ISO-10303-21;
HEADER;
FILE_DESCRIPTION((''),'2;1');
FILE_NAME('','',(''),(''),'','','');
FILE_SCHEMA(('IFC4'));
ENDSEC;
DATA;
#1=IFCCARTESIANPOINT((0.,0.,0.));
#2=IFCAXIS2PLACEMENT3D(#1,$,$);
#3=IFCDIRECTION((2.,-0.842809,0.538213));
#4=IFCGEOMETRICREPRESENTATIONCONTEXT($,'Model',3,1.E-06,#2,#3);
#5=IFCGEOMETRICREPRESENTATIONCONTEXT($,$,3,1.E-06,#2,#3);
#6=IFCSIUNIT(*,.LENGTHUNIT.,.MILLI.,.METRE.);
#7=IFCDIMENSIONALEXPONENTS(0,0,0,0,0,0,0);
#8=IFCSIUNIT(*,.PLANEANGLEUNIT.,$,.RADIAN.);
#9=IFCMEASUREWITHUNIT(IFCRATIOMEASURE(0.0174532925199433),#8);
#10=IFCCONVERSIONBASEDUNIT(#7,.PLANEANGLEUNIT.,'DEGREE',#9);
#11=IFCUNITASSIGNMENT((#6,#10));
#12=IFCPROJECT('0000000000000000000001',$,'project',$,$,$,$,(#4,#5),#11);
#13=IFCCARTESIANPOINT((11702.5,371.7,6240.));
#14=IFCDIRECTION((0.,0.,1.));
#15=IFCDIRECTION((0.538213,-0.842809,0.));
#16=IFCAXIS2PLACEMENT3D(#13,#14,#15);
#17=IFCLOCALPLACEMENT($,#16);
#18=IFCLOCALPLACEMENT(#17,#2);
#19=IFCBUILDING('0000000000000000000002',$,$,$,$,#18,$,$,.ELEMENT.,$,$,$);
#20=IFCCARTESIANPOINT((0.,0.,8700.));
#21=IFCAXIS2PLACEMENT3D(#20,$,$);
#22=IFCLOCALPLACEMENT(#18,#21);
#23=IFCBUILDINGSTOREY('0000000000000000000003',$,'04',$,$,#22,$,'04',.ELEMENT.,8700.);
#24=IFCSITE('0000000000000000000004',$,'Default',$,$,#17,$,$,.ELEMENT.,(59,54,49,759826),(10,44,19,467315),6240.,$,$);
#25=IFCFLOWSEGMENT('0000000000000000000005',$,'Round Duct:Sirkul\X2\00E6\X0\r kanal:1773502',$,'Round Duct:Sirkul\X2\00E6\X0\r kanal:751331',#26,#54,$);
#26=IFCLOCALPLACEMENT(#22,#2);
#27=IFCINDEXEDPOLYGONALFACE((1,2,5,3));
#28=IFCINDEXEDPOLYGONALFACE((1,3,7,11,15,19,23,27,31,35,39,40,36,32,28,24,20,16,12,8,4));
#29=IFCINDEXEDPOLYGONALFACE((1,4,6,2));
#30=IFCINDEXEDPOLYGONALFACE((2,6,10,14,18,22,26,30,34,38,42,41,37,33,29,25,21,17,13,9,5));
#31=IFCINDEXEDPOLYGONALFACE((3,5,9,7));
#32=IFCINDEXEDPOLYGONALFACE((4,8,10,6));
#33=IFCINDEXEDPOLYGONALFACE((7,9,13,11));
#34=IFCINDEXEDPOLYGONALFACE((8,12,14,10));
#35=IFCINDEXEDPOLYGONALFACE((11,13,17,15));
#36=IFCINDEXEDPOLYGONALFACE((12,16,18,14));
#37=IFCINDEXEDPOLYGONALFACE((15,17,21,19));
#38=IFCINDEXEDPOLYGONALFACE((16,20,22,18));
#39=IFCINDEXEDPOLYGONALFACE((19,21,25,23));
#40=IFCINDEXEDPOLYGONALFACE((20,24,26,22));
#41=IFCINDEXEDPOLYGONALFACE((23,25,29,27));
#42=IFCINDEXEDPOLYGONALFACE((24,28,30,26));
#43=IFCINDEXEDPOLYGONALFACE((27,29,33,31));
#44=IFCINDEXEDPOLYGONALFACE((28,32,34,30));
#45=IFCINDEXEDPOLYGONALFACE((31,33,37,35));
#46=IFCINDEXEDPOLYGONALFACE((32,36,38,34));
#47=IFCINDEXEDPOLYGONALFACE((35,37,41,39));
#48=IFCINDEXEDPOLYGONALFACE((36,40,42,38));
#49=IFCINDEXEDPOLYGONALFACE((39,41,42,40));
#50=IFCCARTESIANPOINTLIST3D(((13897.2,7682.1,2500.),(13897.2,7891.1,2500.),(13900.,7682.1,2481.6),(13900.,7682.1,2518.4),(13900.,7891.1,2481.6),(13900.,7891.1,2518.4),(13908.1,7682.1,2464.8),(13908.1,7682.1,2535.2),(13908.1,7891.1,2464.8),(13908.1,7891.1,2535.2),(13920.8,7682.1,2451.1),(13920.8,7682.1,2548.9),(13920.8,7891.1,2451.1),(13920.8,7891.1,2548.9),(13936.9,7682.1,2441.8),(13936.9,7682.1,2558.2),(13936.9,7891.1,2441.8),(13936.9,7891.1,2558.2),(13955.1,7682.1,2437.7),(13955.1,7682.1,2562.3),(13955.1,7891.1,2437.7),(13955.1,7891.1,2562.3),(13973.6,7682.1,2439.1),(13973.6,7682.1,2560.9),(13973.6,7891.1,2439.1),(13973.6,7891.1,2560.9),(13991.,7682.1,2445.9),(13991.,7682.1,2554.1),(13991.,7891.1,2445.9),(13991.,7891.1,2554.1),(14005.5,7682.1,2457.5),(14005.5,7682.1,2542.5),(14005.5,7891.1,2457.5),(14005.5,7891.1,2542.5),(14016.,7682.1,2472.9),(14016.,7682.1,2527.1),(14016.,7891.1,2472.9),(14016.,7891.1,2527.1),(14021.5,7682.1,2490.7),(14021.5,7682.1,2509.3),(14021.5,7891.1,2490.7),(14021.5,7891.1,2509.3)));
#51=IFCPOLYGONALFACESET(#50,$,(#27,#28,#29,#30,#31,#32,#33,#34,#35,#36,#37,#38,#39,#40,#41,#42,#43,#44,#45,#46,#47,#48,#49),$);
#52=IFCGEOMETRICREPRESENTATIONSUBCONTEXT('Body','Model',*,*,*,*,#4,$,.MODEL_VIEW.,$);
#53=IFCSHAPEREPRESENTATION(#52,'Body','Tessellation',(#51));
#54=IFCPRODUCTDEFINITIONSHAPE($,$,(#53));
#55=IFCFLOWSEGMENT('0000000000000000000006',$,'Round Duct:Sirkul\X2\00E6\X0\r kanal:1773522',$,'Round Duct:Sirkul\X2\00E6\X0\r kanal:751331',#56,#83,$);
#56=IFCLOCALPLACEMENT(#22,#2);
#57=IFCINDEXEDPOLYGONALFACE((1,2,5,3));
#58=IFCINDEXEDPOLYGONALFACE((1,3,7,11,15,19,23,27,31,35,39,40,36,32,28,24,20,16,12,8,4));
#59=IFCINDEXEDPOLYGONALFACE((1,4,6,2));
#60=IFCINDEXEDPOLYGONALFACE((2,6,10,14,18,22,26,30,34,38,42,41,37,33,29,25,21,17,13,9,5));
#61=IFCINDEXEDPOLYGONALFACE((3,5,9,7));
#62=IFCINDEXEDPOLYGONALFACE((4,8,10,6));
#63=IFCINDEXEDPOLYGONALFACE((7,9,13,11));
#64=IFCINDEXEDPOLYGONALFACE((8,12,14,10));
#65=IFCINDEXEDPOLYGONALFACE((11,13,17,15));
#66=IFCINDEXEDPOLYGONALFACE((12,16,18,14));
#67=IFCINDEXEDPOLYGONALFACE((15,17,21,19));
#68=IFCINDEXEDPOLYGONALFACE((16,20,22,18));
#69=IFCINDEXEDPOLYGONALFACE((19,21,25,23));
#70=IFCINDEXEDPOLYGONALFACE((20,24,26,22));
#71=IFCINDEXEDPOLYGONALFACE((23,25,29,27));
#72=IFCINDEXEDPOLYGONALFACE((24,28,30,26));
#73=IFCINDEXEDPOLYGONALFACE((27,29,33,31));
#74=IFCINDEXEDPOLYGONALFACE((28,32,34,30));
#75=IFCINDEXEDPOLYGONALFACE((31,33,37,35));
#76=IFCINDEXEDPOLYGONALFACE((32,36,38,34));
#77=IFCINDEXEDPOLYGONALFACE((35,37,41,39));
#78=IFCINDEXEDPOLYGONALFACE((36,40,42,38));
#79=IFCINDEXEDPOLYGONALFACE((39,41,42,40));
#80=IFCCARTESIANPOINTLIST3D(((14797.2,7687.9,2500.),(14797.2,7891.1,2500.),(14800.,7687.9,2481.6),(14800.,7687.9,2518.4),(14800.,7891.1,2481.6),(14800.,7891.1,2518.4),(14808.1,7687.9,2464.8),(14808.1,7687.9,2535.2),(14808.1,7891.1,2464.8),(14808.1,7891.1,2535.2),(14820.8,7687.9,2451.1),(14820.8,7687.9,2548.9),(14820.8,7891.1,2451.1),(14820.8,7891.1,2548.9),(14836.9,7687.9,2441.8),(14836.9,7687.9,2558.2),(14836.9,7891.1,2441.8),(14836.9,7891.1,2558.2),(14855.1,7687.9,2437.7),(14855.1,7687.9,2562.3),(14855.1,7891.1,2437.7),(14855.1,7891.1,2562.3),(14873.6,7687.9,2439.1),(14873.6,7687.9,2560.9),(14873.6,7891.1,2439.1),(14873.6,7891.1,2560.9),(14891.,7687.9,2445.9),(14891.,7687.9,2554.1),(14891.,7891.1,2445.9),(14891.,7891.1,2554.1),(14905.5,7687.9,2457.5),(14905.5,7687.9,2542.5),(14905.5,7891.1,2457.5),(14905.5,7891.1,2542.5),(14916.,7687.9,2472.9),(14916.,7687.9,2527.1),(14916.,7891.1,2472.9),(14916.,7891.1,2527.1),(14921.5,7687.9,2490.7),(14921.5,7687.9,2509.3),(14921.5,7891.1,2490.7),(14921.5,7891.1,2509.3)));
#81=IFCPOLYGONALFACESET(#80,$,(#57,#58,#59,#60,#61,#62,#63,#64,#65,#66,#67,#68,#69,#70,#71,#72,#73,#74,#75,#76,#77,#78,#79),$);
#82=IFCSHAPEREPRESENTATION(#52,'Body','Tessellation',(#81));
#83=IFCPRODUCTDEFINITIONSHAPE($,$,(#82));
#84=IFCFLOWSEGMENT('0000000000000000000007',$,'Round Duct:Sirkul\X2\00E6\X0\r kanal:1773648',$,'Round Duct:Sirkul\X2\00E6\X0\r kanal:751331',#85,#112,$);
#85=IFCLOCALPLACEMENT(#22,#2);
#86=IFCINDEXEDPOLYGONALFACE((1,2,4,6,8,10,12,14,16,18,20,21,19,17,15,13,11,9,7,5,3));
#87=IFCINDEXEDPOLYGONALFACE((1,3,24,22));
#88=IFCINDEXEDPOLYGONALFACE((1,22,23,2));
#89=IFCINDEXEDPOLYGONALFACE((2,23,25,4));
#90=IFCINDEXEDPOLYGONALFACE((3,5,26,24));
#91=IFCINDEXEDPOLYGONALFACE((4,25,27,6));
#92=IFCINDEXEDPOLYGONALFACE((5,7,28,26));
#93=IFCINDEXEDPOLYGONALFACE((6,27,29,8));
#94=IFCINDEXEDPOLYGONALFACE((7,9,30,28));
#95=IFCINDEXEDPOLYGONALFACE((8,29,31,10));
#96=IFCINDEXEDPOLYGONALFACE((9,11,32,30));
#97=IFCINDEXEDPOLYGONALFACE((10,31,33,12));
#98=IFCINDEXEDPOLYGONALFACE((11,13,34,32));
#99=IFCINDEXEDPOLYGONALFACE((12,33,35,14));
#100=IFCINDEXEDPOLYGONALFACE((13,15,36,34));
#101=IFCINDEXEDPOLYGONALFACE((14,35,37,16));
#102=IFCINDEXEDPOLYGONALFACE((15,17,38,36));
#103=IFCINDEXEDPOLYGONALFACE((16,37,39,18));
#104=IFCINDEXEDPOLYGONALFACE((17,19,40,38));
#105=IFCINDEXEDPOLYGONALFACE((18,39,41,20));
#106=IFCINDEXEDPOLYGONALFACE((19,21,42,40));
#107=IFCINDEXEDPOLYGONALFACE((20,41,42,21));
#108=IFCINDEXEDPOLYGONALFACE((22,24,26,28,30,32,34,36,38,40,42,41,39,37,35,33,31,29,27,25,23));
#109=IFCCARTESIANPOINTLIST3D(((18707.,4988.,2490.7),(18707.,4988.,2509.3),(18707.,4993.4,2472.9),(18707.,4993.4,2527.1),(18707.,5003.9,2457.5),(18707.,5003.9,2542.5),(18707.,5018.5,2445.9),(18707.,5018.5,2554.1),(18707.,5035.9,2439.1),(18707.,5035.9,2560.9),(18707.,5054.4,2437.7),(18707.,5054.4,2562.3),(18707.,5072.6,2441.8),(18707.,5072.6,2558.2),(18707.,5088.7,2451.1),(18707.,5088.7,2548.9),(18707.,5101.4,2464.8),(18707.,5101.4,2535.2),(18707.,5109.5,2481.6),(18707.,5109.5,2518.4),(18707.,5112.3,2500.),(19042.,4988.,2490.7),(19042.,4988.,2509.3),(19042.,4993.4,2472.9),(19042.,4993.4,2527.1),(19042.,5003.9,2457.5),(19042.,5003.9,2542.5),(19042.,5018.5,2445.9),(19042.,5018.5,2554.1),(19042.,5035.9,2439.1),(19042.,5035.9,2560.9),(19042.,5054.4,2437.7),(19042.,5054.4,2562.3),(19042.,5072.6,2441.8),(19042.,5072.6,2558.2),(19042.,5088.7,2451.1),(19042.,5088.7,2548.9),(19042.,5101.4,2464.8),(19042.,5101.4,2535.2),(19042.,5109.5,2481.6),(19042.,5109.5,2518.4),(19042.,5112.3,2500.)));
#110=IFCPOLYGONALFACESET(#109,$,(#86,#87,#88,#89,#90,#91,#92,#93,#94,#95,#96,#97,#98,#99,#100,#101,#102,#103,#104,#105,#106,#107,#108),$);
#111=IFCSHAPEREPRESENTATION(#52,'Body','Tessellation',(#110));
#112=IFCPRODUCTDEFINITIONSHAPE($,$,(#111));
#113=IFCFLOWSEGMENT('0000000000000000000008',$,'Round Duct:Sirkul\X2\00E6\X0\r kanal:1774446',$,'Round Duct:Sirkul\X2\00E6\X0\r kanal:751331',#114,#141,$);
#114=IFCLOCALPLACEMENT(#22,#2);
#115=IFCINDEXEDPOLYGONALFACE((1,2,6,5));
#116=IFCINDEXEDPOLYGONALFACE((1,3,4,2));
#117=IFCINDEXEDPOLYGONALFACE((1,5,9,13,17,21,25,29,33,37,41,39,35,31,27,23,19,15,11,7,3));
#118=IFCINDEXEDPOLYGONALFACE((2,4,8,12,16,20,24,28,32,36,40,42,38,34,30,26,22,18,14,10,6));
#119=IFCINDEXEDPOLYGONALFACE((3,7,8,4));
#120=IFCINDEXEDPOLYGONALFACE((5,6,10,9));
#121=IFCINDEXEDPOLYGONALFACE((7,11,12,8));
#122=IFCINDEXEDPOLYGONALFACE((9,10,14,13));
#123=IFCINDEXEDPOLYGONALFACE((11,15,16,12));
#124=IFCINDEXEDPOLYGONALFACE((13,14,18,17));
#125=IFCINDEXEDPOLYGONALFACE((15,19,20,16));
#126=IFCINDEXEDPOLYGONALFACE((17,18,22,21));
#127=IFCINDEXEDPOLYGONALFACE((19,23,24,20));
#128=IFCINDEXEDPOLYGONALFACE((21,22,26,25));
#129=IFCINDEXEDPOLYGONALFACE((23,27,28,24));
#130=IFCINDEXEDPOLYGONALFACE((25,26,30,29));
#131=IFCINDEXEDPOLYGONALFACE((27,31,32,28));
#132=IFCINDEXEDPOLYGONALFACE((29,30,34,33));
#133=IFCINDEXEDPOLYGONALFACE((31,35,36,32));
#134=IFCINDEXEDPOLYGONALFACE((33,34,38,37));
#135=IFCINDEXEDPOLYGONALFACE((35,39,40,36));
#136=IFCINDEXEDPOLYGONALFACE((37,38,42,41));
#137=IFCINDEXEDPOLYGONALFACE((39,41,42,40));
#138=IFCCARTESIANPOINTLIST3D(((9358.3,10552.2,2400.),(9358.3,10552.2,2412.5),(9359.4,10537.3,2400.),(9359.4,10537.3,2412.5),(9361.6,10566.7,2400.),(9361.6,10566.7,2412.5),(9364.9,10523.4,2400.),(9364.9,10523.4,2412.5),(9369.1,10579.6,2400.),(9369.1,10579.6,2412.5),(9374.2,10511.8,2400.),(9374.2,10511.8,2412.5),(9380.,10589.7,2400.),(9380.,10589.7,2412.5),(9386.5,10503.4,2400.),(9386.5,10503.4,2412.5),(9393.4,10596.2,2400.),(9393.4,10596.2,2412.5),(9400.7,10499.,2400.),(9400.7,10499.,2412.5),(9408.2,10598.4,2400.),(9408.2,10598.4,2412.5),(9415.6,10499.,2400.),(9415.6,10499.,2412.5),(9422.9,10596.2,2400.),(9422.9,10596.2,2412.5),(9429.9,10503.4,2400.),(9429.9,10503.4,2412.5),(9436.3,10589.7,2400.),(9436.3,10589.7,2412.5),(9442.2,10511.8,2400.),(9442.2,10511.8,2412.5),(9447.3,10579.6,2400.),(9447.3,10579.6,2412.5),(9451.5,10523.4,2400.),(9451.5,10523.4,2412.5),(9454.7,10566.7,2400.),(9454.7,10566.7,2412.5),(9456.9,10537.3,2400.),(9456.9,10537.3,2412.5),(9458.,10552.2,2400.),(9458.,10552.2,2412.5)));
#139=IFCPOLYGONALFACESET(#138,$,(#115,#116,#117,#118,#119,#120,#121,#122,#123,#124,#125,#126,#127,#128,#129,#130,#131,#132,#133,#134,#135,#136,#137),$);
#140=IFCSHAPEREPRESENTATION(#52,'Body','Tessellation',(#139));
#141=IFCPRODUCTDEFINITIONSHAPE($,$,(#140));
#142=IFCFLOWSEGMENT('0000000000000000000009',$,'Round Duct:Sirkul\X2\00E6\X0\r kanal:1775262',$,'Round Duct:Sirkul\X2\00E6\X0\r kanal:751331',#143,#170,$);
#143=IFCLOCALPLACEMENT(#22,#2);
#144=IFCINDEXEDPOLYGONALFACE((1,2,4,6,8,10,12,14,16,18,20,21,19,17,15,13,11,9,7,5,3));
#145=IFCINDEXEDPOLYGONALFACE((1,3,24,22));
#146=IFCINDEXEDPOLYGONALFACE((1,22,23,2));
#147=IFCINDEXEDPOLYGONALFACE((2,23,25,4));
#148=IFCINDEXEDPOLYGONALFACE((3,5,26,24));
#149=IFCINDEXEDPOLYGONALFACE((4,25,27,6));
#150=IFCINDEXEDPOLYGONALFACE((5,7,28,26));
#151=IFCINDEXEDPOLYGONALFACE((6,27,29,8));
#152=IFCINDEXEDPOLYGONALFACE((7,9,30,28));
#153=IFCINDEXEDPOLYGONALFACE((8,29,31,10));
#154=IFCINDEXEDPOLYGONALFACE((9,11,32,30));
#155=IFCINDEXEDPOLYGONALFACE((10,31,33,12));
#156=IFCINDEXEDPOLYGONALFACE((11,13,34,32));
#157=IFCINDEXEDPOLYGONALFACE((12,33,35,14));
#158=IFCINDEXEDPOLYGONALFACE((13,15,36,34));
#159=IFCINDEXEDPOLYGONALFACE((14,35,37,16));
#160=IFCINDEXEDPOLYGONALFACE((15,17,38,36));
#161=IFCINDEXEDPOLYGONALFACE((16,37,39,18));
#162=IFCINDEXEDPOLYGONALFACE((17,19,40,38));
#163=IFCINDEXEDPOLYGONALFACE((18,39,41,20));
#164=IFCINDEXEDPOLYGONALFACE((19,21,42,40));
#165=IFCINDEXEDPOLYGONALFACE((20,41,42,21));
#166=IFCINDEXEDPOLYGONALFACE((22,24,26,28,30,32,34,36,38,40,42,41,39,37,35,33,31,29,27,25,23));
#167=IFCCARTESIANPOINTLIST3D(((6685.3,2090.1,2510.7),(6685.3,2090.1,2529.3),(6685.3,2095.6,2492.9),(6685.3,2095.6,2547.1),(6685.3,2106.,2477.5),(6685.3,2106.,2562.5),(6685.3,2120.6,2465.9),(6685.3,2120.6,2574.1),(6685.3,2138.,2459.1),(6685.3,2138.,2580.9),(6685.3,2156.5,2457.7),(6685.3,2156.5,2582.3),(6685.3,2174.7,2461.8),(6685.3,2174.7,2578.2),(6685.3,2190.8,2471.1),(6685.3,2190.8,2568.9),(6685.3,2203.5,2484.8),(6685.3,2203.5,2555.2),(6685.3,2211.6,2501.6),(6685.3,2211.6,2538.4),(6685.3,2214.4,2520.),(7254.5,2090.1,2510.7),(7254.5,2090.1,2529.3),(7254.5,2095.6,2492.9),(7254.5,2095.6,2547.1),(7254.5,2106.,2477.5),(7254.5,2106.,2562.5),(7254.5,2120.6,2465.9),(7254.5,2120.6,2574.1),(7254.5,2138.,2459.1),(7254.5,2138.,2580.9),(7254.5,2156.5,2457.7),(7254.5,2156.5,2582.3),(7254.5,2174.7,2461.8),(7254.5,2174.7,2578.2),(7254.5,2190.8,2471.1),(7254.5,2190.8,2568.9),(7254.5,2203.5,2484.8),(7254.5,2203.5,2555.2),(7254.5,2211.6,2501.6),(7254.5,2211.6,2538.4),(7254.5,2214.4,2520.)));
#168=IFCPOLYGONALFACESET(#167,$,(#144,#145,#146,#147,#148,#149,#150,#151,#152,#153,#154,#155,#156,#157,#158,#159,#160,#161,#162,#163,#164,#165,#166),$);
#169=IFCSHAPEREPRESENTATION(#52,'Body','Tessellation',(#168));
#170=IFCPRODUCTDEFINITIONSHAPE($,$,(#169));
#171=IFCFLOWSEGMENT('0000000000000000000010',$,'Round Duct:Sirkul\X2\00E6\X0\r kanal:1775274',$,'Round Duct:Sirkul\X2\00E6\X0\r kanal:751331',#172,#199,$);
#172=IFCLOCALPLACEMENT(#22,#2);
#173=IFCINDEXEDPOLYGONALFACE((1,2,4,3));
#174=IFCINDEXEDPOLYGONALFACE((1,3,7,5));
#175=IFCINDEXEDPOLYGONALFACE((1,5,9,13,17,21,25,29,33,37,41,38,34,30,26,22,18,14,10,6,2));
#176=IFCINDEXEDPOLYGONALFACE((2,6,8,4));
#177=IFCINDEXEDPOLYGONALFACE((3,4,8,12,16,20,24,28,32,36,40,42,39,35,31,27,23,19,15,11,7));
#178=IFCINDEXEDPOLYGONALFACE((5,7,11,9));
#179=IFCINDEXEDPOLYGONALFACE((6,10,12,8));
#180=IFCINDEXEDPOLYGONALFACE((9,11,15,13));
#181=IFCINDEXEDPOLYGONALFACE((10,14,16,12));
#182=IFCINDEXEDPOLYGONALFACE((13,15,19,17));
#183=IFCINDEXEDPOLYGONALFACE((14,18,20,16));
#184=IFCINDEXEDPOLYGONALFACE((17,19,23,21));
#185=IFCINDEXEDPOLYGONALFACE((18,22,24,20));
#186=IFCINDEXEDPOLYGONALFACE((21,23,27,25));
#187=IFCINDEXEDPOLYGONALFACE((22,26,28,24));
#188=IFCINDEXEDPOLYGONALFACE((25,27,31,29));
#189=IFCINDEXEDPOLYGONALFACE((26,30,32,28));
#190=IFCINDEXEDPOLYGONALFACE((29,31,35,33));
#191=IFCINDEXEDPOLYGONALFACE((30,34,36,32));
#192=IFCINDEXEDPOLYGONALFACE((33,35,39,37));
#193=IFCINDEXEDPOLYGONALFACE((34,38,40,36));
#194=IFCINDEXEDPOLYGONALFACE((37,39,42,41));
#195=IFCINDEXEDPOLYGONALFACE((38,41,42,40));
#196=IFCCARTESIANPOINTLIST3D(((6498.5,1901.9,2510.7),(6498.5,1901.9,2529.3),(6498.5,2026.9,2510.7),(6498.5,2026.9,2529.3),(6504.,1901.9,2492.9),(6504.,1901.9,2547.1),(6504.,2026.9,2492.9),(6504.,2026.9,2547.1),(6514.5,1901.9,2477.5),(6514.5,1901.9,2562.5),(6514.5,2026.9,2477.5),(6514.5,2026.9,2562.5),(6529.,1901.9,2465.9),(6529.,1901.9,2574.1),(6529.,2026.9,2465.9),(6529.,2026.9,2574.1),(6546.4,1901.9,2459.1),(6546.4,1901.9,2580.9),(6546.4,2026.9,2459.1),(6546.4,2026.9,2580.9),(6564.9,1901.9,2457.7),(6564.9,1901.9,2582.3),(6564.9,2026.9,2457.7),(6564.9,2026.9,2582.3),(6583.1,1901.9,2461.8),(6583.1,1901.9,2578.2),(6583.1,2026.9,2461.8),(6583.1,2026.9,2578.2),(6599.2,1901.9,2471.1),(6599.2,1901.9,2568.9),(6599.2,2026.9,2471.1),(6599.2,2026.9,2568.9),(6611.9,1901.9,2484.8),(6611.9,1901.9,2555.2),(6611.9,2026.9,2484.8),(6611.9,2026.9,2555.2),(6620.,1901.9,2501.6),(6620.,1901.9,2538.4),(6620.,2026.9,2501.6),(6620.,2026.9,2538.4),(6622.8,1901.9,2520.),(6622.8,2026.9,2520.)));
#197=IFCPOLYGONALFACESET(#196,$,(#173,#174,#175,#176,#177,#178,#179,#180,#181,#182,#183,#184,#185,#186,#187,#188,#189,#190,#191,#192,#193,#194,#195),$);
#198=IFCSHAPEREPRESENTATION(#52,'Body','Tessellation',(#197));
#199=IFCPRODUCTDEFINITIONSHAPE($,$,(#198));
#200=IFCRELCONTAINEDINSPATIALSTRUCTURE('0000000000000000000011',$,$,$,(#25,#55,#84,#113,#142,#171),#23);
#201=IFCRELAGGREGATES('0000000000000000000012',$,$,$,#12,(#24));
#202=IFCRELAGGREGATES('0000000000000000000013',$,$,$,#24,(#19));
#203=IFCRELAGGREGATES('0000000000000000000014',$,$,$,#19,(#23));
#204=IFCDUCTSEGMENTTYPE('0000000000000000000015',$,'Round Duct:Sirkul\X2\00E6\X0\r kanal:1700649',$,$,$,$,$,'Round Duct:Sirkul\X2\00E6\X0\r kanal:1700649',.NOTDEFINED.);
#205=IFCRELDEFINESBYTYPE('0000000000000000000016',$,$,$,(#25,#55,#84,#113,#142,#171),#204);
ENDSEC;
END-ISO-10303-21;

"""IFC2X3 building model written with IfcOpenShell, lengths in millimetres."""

from ifc_helpers import new_model, entity, si_unit, converted_unit, direction, frame, frame_2d, origin, place, context, subcontext, project, spatial, circle, extrude, type_object, element, save


model = new_model("IFC2X3")

# Units and contexts
model_context = context("Model", 3, precision=1e-06, world=origin(), true_north=direction((2.0, -0.842809, 0.538213)))
context_of_model = context(None, 3, precision=1e-06, world=origin(), true_north=direction((2.0, -0.842809, 0.538213)))
body_context = subcontext(model_context, "Body", "Model", "MODEL_VIEW")
ifc_project = project(units=[si_unit("LENGTHUNIT", "METRE", prefix="MILLI"), converted_unit("PLANEANGLEUNIT", "DEGREE", entity("IfcRatioMeasure", 0.0174532925199433), si_unit("PLANEANGLEUNIT", "RADIAN"), dimensions=[0, 0, 0, 0, 0, 0, 0])], contexts=[model_context, context_of_model])

# Site, building, storey
site_placement = place(None, frame((11702.5, 371.7, 6240.0), z_axis=(0.0, 0.0, 1.0), x_axis=(0.538213, -0.842809, 0.0)))
site = spatial("IfcSite", under=ifc_project, at=site_placement, Name="Default", CompositionType="ELEMENT", RefLatitude=(59, 54, 49, 759826), RefLongitude=(10, 44, 19, 467315), RefElevation=6240.0)
building_placement = place(site_placement, origin())
building = spatial("IfcBuilding", under=site, at=building_placement, CompositionType="ELEMENT")
storey_placement = place(building_placement, frame((0.0, 0.0, 8700.0)))
storey = spatial("IfcBuildingStorey", under=building, at=storey_placement, Name="04", LongName="04", CompositionType="ELEMENT", Elevation=8700.0)

# Flow segments
duct_segment_type = type_object("IfcDuctSegmentType", Name="Round Duct:Sirkulær kanal:1700649", ElementType="Round Duct:Sirkulær kanal:1700649", PredefinedType="NOTDEFINED")
flow_segment_1_placement = place(storey_placement, origin())
element("IfcFlowSegment", 1, at=flow_segment_1_placement, inside=storey, type_object=duct_segment_type, Name="Round Duct:Sirkulær kanal:1773502", ObjectType="Round Duct:Sirkulær kanal:751331", context=body_context, shape_type="SweptSolid", body=[
    extrude(circle(Radius=62.5, at=frame_2d((0.0, 0.0), x_axis=(1.0, 0.0))), frame((13959.7, 7682.1, 2500.0), z_axis=(0.0, 1.0, 0.0), x_axis=(-1.0, 0.0, 0.0)), (0.0, 0.0, 1.0), 209.0),
])
flow_segment_2_placement = place(storey_placement, origin())
element("IfcFlowSegment", 2, at=flow_segment_2_placement, inside=storey, type_object=duct_segment_type, Name="Round Duct:Sirkulær kanal:1773522", ObjectType="Round Duct:Sirkulær kanal:751331", context=body_context, shape_type="SweptSolid", body=[
    extrude(circle(Radius=62.5, at=frame_2d((0.0, 0.0), x_axis=(1.0, 0.0))), frame((14859.7, 7687.9, 2500.0), z_axis=(0.0, 1.0, 0.0), x_axis=(-1.0, 0.0, 0.0)), (0.0, 0.0, 1.0), 203.2),
])
flow_segment_3_placement = place(storey_placement, origin())
element("IfcFlowSegment", 3, at=flow_segment_3_placement, inside=storey, type_object=duct_segment_type, Name="Round Duct:Sirkulær kanal:1773648", ObjectType="Round Duct:Sirkulær kanal:751331", context=body_context, shape_type="SweptSolid", body=[
    extrude(circle(Radius=62.5, at=frame_2d((0.0, 0.0), x_axis=(1.0, 0.0))), frame((18707.0, 5049.8, 2500.0), z_axis=(1.0, 0.0, 0.0), x_axis=(0.0, 1.0, 0.0)), (0.0, 0.0, 1.0), 335.0),
])
flow_segment_4_placement = place(storey_placement, origin())
element("IfcFlowSegment", 4, at=flow_segment_4_placement, inside=storey, type_object=duct_segment_type, Name="Round Duct:Sirkulær kanal:1774446", ObjectType="Round Duct:Sirkulær kanal:751331", context=body_context, shape_type="SweptSolid", body=[
    extrude(circle(Radius=50.0, at=frame_2d((0.0, 0.0), x_axis=(1.0, 0.0))), frame((9408.2, 10548.4, 2400.0), z_axis=(0.0, 0.0, 1.0), x_axis=(0.0, 1.0, 0.0)), (0.0, 0.0, 1.0), 12.5),
])
flow_segment_5_placement = place(storey_placement, origin())
element("IfcFlowSegment", 5, at=flow_segment_5_placement, inside=storey, type_object=duct_segment_type, Name="Round Duct:Sirkulær kanal:1775262", ObjectType="Round Duct:Sirkulær kanal:751331", context=body_context, shape_type="SweptSolid", body=[
    extrude(circle(Radius=62.5, at=frame_2d((0.0, 0.0), x_axis=(1.0, 0.0))), frame((6685.3, 2151.9, 2520.0), z_axis=(1.0, 0.0, 0.0), x_axis=(0.0, 1.0, 0.0)), (0.0, 0.0, 1.0), 569.2),
])
flow_segment_6_placement = place(storey_placement, origin())
element("IfcFlowSegment", 6, at=flow_segment_6_placement, inside=storey, type_object=duct_segment_type, Name="Round Duct:Sirkulær kanal:1775274", ObjectType="Round Duct:Sirkulær kanal:751331", context=body_context, shape_type="SweptSolid", body=[
    extrude(circle(Radius=62.5, at=frame_2d((0.0, 0.0), x_axis=(1.0, 0.0))), frame((6560.3, 1901.9, 2520.0), z_axis=(0.0, 1.0, 0.0), x_axis=(1.0, 0.0, 0.0)), (0.0, 0.0, 1.0), 125.0),
])

save(model, "model.ifc")
